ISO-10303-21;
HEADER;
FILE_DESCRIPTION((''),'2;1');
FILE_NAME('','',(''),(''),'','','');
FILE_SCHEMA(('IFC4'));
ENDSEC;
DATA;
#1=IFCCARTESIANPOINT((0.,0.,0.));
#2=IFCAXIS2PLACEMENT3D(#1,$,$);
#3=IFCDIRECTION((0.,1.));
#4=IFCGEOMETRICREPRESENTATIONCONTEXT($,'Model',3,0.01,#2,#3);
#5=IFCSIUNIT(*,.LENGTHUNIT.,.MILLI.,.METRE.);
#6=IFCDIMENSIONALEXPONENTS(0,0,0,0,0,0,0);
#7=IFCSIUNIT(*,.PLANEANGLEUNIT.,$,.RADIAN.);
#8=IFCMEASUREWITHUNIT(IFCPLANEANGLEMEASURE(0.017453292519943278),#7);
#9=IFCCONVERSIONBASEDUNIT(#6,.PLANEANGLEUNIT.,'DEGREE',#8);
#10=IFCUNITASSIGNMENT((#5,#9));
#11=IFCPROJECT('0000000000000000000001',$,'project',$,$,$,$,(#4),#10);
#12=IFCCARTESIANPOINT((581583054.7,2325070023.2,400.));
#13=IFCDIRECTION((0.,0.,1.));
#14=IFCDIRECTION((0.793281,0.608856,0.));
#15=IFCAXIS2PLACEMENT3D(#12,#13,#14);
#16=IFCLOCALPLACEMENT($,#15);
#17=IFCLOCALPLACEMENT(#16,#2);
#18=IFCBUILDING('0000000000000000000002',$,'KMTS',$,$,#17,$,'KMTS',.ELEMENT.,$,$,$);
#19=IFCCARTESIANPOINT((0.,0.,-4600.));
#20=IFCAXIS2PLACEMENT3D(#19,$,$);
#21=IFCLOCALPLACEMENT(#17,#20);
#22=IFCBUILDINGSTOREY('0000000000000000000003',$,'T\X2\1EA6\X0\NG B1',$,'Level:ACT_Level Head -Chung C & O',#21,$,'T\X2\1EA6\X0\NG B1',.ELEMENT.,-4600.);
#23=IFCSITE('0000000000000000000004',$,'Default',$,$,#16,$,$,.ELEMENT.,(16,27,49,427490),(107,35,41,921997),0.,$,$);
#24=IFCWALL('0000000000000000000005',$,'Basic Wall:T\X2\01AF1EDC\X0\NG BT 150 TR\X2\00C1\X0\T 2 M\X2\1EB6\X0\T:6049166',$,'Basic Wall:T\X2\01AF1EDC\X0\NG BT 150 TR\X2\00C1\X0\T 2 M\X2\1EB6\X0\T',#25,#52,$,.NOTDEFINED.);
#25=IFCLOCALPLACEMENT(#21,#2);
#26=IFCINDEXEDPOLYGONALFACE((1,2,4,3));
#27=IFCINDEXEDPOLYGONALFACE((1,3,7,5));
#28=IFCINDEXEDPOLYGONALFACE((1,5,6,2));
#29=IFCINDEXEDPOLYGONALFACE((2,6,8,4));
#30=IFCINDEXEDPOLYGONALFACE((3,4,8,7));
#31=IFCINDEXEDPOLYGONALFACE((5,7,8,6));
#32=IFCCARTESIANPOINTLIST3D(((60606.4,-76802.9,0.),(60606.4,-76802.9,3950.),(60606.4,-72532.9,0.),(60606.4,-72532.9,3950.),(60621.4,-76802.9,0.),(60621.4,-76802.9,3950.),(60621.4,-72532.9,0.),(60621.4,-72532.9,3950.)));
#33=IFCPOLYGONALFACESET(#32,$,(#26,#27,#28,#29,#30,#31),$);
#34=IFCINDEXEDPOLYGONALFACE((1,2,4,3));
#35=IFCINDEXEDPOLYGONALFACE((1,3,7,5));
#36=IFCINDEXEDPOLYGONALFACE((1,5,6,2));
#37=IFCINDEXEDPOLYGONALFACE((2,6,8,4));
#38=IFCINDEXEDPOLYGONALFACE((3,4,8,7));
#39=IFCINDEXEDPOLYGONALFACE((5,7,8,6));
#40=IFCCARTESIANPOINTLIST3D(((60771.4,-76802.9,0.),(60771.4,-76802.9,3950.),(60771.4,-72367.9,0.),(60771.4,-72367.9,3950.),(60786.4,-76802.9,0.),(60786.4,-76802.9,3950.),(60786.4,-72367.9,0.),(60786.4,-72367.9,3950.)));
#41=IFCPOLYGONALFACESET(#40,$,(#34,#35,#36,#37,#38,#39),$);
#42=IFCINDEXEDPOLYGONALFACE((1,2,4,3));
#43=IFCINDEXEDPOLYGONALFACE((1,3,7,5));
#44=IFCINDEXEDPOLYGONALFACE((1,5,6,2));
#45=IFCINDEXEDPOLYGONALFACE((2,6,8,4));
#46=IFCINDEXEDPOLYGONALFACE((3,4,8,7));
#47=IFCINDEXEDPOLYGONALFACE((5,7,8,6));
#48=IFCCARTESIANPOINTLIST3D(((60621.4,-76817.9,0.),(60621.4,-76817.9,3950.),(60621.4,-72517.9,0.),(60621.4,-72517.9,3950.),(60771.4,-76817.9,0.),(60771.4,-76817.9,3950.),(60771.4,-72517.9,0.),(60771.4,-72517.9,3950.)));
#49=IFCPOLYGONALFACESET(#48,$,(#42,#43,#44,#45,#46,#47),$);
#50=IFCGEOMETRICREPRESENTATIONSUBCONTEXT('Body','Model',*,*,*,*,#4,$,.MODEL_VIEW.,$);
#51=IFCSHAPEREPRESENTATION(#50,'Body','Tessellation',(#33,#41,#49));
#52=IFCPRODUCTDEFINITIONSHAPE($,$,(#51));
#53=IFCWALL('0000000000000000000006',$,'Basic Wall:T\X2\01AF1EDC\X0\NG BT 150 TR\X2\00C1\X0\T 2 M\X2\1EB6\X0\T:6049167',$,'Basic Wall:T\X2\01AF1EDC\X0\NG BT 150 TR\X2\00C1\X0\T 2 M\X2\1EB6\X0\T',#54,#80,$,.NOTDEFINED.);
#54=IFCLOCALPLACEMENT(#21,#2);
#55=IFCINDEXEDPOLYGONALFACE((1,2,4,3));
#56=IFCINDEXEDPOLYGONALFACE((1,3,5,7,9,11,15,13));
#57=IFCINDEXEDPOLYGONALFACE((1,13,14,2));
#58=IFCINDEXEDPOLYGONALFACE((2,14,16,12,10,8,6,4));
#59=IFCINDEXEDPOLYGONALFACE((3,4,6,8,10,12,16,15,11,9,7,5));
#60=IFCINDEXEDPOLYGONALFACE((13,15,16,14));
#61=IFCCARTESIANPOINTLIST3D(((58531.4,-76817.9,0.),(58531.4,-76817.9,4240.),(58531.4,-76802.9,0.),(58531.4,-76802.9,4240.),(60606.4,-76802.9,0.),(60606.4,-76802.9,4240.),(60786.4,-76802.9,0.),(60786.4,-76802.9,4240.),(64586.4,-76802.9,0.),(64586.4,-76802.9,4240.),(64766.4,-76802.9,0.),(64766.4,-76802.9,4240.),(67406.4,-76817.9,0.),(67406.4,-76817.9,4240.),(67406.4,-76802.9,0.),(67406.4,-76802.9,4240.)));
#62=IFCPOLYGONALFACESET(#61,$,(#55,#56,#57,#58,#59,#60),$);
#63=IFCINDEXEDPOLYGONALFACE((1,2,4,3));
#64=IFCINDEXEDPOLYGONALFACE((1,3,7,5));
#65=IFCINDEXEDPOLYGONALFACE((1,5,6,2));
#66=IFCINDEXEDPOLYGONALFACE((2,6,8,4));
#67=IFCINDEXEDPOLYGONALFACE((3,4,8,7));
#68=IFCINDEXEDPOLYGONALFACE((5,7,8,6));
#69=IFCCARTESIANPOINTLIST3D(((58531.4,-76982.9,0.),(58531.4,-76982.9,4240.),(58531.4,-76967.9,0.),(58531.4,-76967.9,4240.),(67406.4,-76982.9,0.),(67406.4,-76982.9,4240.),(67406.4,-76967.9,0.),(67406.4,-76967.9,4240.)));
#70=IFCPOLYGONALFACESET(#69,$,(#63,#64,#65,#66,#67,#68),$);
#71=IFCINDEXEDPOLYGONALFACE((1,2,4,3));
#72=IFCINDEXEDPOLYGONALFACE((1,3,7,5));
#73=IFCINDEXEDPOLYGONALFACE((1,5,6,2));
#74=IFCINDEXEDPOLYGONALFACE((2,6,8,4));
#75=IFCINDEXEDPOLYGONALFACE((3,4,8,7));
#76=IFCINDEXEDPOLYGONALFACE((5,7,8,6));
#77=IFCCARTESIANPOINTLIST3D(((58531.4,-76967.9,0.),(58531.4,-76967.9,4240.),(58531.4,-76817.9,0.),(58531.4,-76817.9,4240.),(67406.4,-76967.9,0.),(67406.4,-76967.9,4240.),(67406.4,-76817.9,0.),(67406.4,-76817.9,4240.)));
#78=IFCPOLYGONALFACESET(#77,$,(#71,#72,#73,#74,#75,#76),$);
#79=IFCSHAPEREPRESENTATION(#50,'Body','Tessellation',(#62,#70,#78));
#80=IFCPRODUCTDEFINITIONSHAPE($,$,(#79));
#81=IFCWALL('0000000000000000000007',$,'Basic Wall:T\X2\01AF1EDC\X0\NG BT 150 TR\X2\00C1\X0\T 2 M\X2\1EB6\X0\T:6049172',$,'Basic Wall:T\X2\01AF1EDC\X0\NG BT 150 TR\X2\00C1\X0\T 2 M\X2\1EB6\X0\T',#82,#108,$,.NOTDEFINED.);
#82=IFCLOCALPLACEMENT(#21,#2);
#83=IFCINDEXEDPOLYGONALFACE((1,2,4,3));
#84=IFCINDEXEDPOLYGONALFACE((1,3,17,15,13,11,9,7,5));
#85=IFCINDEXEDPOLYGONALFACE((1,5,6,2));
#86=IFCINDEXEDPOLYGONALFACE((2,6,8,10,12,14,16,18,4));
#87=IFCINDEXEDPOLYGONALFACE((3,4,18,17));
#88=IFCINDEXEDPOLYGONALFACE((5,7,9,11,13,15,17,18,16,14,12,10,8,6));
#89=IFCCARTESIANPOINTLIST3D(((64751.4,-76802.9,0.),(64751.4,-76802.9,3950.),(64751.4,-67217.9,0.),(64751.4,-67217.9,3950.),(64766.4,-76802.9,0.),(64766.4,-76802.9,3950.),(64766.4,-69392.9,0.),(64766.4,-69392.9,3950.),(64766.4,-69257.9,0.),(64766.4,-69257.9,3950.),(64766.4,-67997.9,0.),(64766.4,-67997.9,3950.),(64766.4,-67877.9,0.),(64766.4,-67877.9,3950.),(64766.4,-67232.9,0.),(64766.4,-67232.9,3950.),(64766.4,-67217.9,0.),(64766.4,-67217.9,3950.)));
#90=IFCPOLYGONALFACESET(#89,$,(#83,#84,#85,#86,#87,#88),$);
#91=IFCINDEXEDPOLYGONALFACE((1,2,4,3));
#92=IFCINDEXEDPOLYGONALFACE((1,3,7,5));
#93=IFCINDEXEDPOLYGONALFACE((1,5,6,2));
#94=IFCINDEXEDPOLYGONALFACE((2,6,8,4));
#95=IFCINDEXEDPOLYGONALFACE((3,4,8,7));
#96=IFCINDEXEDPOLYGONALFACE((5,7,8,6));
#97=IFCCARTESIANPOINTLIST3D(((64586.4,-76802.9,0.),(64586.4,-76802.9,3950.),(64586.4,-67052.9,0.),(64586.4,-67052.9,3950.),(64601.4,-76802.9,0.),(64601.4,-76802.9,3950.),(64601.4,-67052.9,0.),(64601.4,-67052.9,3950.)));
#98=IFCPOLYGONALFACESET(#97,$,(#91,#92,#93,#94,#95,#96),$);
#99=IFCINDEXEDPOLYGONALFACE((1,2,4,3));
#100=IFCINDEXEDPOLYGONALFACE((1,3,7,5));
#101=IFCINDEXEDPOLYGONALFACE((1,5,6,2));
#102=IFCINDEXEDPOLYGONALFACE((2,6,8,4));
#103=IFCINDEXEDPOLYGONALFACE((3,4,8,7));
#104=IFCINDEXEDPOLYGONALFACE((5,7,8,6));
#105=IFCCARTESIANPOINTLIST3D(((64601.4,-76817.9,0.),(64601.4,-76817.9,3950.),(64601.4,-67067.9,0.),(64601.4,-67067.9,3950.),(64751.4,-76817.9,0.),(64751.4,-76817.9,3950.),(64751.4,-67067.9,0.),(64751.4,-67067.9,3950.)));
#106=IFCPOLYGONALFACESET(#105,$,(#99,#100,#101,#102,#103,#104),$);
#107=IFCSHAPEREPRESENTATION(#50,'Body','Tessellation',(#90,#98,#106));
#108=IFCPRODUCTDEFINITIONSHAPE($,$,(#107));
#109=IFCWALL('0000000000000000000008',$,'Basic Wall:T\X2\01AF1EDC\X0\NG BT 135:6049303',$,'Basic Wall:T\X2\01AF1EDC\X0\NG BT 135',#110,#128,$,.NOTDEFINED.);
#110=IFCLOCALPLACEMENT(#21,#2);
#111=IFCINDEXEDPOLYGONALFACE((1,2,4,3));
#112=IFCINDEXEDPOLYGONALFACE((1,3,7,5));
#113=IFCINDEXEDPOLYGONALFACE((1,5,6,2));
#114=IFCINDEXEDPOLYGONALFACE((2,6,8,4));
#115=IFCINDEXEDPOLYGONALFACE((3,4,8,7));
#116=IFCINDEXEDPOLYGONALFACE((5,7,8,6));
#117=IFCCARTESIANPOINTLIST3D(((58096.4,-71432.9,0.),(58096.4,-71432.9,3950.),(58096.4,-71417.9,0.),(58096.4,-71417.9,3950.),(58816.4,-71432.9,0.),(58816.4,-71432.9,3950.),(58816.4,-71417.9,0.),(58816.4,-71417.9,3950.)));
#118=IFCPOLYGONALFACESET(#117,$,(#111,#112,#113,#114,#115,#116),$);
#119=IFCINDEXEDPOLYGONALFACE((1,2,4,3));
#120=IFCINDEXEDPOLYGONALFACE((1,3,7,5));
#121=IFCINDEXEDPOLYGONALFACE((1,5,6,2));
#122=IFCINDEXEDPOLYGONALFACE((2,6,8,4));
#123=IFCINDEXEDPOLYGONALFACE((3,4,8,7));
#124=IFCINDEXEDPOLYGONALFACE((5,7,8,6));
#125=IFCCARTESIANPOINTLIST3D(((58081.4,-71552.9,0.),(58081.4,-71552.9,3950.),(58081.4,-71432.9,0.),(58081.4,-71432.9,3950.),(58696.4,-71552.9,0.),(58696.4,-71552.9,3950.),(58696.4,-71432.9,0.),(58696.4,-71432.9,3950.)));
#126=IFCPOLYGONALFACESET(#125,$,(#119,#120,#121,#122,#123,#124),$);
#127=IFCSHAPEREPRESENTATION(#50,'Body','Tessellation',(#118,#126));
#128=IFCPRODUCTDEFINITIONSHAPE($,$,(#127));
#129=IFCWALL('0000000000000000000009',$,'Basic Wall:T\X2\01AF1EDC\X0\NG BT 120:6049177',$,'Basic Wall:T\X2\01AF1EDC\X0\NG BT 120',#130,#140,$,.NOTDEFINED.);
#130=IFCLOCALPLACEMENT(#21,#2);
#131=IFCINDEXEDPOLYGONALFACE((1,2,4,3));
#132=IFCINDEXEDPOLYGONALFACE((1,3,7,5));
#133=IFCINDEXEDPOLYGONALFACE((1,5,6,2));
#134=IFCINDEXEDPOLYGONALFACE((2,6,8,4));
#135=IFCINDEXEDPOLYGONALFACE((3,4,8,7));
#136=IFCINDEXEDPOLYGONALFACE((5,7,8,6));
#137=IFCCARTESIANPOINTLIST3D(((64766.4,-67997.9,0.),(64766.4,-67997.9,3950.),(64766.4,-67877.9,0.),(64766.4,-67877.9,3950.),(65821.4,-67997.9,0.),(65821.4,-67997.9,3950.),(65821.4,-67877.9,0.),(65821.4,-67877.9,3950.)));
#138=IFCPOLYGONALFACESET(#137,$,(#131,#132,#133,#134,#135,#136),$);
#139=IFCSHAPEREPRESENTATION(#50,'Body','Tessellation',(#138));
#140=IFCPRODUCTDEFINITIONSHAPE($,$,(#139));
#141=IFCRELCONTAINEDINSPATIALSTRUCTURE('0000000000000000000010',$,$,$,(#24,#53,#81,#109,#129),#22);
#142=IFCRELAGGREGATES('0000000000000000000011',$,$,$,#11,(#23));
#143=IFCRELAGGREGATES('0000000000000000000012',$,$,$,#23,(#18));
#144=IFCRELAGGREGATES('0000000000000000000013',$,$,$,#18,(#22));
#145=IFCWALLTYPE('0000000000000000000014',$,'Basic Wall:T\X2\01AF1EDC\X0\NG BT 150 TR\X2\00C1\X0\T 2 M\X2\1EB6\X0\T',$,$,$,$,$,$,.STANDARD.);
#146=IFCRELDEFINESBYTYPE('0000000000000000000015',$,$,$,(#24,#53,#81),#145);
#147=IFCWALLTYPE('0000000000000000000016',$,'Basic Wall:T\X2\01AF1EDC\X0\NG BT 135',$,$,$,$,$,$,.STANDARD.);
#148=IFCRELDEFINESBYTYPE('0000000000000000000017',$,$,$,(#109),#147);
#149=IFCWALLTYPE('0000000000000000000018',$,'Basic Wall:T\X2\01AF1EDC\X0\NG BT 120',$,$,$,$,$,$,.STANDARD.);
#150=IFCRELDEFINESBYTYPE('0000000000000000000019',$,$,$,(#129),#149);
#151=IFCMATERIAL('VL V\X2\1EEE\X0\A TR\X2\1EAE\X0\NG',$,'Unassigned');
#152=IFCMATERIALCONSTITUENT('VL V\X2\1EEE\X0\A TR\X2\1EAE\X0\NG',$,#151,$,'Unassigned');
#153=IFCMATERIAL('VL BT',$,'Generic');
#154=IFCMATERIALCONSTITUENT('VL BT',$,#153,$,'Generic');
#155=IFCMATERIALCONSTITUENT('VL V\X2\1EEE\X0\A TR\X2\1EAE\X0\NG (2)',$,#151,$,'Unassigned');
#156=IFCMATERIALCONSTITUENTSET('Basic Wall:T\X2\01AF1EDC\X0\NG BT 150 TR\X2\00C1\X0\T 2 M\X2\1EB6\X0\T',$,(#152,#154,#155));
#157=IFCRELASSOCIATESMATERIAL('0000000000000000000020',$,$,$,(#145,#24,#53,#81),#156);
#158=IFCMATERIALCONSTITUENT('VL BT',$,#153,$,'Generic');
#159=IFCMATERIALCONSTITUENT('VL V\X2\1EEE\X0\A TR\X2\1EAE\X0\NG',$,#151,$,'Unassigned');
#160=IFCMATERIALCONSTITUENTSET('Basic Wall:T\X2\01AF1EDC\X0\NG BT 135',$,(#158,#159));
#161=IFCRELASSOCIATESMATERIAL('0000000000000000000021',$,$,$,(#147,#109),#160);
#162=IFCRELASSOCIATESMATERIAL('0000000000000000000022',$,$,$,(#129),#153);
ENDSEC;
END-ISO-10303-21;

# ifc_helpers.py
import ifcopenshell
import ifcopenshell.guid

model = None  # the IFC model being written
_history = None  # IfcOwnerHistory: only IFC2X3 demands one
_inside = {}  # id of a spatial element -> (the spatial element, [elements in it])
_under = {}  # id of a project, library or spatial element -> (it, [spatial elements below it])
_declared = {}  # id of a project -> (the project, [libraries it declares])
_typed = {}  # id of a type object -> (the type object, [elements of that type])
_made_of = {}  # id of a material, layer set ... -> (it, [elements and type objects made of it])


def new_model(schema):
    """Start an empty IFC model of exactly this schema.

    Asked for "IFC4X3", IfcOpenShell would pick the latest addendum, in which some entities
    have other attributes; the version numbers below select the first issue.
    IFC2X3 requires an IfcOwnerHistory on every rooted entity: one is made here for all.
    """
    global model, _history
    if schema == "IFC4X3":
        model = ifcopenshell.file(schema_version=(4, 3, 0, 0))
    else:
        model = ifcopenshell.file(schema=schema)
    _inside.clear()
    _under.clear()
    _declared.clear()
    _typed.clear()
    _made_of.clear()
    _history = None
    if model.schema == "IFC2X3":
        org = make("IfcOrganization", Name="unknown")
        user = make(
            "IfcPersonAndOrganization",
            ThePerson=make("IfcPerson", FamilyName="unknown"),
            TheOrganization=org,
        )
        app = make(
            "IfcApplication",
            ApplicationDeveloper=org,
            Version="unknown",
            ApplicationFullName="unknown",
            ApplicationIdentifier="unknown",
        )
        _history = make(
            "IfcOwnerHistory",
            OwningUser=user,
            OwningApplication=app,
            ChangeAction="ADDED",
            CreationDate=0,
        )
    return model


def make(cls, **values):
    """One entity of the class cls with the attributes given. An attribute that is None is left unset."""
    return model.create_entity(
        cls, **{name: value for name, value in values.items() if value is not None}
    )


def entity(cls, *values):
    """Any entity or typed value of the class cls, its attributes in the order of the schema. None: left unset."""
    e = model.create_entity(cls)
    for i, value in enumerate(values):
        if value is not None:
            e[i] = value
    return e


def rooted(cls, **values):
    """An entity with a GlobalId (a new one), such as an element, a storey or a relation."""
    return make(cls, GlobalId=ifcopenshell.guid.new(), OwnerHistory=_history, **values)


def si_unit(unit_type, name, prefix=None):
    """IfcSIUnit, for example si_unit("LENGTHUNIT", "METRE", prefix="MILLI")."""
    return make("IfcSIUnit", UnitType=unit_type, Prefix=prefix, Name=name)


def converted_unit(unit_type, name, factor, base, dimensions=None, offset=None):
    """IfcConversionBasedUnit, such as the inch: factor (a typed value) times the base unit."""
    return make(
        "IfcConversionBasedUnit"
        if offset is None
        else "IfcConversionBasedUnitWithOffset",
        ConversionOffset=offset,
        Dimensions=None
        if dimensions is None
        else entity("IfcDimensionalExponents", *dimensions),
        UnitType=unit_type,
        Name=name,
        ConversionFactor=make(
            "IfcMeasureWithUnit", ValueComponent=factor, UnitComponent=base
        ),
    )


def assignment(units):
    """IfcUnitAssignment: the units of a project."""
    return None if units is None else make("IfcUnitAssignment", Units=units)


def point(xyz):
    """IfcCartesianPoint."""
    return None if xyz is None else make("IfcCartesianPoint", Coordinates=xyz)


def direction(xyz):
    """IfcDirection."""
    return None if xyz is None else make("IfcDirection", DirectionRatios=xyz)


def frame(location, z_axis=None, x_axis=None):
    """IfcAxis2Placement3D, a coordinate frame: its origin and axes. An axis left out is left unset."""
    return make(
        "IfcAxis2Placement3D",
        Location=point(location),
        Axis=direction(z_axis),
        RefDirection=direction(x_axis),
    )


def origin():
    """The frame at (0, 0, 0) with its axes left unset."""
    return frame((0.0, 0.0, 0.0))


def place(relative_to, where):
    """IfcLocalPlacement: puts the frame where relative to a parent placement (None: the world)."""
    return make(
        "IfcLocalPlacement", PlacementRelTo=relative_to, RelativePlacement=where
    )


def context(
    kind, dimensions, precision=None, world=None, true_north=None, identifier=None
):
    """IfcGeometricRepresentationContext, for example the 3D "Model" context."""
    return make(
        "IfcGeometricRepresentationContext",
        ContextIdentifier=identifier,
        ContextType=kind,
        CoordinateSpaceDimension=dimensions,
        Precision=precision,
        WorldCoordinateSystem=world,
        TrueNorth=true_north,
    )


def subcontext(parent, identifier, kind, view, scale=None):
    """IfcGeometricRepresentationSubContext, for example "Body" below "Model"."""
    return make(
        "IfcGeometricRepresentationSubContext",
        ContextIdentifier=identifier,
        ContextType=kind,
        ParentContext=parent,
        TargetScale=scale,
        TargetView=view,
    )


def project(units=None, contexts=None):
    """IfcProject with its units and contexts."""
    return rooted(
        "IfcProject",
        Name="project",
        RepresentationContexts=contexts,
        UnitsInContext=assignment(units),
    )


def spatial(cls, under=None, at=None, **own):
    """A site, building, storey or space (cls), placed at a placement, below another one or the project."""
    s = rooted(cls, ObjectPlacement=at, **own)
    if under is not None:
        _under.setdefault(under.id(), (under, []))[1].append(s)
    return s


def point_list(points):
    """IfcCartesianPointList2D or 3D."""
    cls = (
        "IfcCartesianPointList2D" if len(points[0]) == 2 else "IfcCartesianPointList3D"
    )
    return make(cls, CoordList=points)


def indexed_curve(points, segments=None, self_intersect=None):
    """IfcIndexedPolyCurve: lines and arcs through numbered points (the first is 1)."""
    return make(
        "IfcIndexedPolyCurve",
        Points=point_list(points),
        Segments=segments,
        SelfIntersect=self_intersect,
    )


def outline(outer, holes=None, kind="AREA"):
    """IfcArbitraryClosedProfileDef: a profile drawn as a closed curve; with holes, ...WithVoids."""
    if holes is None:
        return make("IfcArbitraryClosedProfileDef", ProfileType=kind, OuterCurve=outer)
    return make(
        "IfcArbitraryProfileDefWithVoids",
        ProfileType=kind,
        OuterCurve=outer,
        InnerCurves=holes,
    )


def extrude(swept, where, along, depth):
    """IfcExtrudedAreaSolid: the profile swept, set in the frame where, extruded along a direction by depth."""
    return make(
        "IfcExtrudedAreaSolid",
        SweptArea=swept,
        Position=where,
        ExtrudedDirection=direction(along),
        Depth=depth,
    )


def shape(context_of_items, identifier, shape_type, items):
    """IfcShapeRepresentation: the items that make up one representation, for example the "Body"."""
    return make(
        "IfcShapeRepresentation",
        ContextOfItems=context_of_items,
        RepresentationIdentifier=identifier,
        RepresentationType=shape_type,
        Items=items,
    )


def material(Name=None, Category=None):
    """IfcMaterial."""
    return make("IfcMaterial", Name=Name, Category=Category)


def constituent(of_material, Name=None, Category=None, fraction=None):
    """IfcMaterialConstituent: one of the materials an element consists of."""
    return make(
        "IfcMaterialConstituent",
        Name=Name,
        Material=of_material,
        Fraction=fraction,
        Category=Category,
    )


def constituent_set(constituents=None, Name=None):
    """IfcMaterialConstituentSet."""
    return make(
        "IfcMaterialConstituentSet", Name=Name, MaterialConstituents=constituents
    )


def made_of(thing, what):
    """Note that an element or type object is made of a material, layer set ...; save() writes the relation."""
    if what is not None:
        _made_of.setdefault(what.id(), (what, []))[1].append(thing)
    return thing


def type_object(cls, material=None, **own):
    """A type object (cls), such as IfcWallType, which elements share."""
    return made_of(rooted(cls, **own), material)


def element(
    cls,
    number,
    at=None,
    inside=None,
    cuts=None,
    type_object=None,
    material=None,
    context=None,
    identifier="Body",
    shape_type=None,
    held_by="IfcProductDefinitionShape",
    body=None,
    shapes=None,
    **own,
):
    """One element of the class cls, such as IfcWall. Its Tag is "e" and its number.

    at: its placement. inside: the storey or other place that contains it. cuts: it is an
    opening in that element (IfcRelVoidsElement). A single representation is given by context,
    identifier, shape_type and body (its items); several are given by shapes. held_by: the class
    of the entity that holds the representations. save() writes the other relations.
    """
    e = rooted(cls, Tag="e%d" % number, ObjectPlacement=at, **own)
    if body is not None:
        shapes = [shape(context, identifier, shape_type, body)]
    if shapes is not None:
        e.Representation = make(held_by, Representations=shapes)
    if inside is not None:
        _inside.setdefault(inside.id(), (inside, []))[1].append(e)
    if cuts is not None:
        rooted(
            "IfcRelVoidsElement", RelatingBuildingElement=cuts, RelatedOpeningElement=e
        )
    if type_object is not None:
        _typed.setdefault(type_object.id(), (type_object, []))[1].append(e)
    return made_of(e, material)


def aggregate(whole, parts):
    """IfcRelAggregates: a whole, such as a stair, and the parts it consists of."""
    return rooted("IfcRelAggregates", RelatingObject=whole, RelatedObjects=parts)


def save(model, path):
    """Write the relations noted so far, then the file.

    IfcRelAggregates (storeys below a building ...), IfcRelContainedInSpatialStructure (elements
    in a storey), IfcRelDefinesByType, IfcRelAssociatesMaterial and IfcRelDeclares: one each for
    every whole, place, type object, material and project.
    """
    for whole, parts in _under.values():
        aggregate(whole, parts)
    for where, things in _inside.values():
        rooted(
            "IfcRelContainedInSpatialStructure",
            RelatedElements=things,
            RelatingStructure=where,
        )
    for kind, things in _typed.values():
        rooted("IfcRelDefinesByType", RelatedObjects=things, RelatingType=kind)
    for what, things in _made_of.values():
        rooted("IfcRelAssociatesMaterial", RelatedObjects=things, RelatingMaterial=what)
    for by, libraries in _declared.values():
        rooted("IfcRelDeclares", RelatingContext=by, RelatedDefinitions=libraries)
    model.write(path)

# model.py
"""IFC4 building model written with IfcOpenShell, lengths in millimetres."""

from ifc_helpers import new_model, entity, si_unit, converted_unit, direction, frame, origin, place, context, subcontext, project, spatial, indexed_curve, outline, extrude, material, constituent, constituent_set, type_object, element, save


model = new_model("IFC4")

# Units and contexts
model_context = context("Model", 3, precision=0.01, world=origin(), true_north=direction((0.0, 1.0)))
body_context = subcontext(model_context, "Body", "Model", "MODEL_VIEW")
ifc_project = project(units=[si_unit("LENGTHUNIT", "METRE", prefix="MILLI"), converted_unit("PLANEANGLEUNIT", "DEGREE", entity("IfcPlaneAngleMeasure", 0.017453292519943278), si_unit("PLANEANGLEUNIT", "RADIAN"), dimensions=[0, 0, 0, 0, 0, 0, 0])], contexts=[model_context])

# Site, building, storey
site_placement = place(None, frame((581583054.7, 2325070023.2, 400.0), z_axis=(0.0, 0.0, 1.0), x_axis=(0.793281, 0.608856, 0.0)))
site = spatial("IfcSite", under=ifc_project, at=site_placement, Name="Default", CompositionType="ELEMENT", RefLatitude=(16, 27, 49, 427490), RefLongitude=(107, 35, 41, 921997), RefElevation=0.0)
building_placement = place(site_placement, origin())
building = spatial("IfcBuilding", under=site, at=building_placement, Name="KMTS", LongName="KMTS", CompositionType="ELEMENT")
storey_placement = place(building_placement, frame((0.0, 0.0, -4600.0)))
storey = spatial("IfcBuildingStorey", under=building, at=storey_placement, Name="TẦNG B1", ObjectType="Level:ACT_Level Head -Chung C & O", LongName="TẦNG B1", CompositionType="ELEMENT", Elevation=-4600.0)

# Shared definitions
ifc_material_1 = material(Name="VL VỮA TRẮNG", Category="Unassigned")
ifc_constituent_1 = constituent(ifc_material_1, Name="VL VỮA TRẮNG", Category="Unassigned")
ifc_material_2 = material(Name="VL BT", Category="Generic")
ifc_constituent_2 = constituent(ifc_material_2, Name="VL BT", Category="Generic")
ifc_constituent_3 = constituent(ifc_material_1, Name="VL VỮA TRẮNG (2)", Category="Unassigned")
ifc_constituent_set_1 = constituent_set(constituents=[ifc_constituent_1, ifc_constituent_2, ifc_constituent_3], Name="Basic Wall:TƯỜNG BT 150 TRÁT 2 MẶT")
wall_type_1 = type_object("IfcWallType", Name="Basic Wall:TƯỜNG BT 150 TRÁT 2 MẶT", PredefinedType="STANDARD", material=ifc_constituent_set_1)

# Walls
wall_1_placement = place(storey_placement, frame((60696.4, -72532.9, 0.0), z_axis=(0.0, 0.0, 1.0), x_axis=(0.0, -1.0, 0.0)))
element("IfcWall", 1, at=wall_1_placement, inside=storey, type_object=wall_type_1, material=ifc_constituent_set_1, Name="Basic Wall:TƯỜNG BT 150 TRÁT 2 MẶT:6049166", ObjectType="Basic Wall:TƯỜNG BT 150 TRÁT 2 MẶT", PredefinedType="NOTDEFINED", context=body_context, shape_type="SweptSolid", body=[
    extrude(outline(indexed_curve([(-7.5, -2135.0), (7.5, -2135.0), (7.5, 2135.0), (-7.5, 2135.0), (-7.5, -2135.0)], self_intersect=False)), frame((2135.0, -82.5, 0.0), z_axis=(0.0, 0.0, 1.0), x_axis=(0.0, 1.0, 0.0)), (0.0, 0.0, 1.0), 3950.0),
    extrude(outline(indexed_curve([(-7.5, -2217.5), (7.5, -2217.5), (7.5, 2217.5), (-7.5, 2217.5), (-7.5, -2217.5)], self_intersect=False)), frame((2052.5, 82.5, 0.0), z_axis=(0.0, 0.0, 1.0), x_axis=(0.0, -1.0, 0.0)), (0.0, 0.0, 1.0), 3950.0),
    extrude(outline(indexed_curve([(-2150.0, -75.0), (2150.0, -75.0), (2150.0, 75.0), (-2150.0, 75.0), (-2150.0, -75.0)], self_intersect=False)), frame((2135.0, 0.0, 0.0)), (0.0, 0.0, 1.0), 3950.0),
])
wall_2_placement = place(storey_placement, frame((67406.4, -76892.9, 0.0), z_axis=(0.0, 0.0, 1.0), x_axis=(-1.0, 0.0, 0.0)))
element("IfcWall", 2, at=wall_2_placement, inside=storey, type_object=wall_type_1, material=ifc_constituent_set_1, Name="Basic Wall:TƯỜNG BT 150 TRÁT 2 MẶT:6049167", ObjectType="Basic Wall:TƯỜNG BT 150 TRÁT 2 MẶT", PredefinedType="NOTDEFINED", context=body_context, shape_type="SweptSolid", body=[
    extrude(outline(indexed_curve([(-1938.7, -3.7), (-1758.7, -3.7), (2041.3, -3.8), (2221.3, -3.8), (4296.2, -3.8), (4296.2, 11.2), (-4578.7, 11.3), (-4578.7, -3.7), (-1938.7, -3.7)], self_intersect=False)), frame((4578.7, -86.3, 0.0)), (0.0, 0.0, 1.0), 4240.0),
    extrude(outline(indexed_curve([(-7.5, -4437.5), (7.5, -4437.5), (7.5, 4437.5), (-7.5, 4437.5), (-7.5, -4437.5)], self_intersect=False)), frame((4437.5, 82.5, 0.0), z_axis=(0.0, 0.0, 1.0), x_axis=(0.0, -1.0, 0.0)), (0.0, 0.0, 1.0), 4240.0),
    extrude(outline(indexed_curve([(-4437.5, -75.0), (4437.5, -75.0), (4437.5, 75.0), (-4437.5, 75.0), (-4437.5, -75.0)], self_intersect=False)), frame((4437.5, 0.0, 0.0)), (0.0, 0.0, 1.0), 4240.0),
])
wall_3_placement = place(storey_placement, frame((64676.4, -76802.9, 0.0), z_axis=(0.0, 0.0, 1.0), x_axis=(0.0, 1.0, 0.0)))
element("IfcWall", 3, at=wall_3_placement, inside=storey, type_object=wall_type_1, material=ifc_constituent_set_1, Name="Basic Wall:TƯỜNG BT 150 TRÁT 2 MẶT:6049172", ObjectType="Basic Wall:TƯỜNG BT 150 TRÁT 2 MẶT", PredefinedType="NOTDEFINED", context=body_context, shape_type="SweptSolid", body=[
    extrude(outline(indexed_curve([(585.0, -3.3), (720.0, -3.3), (1980.0, -3.3), (2100.0, -3.3), (2745.0, -3.3), (2760.0, -3.3), (2760.0, 11.7), (-6825.0, 11.7), (-6825.0, -3.3), (585.0, -3.3)], self_intersect=False)), frame((6825.0, -86.7, 0.0)), (0.0, 0.0, 1.0), 3950.0),
    extrude(outline(indexed_curve([(-7.5, -4875.0), (7.5, -4875.0), (7.5, 4875.0), (-7.5, 4875.0), (-7.5, -4875.0)], self_intersect=False)), frame((4875.0, 82.5, 0.0), z_axis=(0.0, 0.0, 1.0), x_axis=(0.0, -1.0, 0.0)), (0.0, 0.0, 1.0), 3950.0),
    extrude(outline(indexed_curve([(-4875.0, -75.0), (4875.0, -75.0), (4875.0, 75.0), (-4875.0, 75.0), (-4875.0, -75.0)], self_intersect=False)), frame((4860.0, 0.0, 0.0)), (0.0, 0.0, 1.0), 3950.0),
])

# Shared definitions
ifc_constituent_4 = constituent(ifc_material_2, Name="VL BT", Category="Generic")
ifc_constituent_5 = constituent(ifc_material_1, Name="VL VỮA TRẮNG", Category="Unassigned")
ifc_constituent_set_2 = constituent_set(constituents=[ifc_constituent_4, ifc_constituent_5], Name="Basic Wall:TƯỜNG BT 135")
wall_type_2 = type_object("IfcWallType", Name="Basic Wall:TƯỜNG BT 135", PredefinedType="STANDARD", material=ifc_constituent_set_2)

# Walls
wall_4_placement = place(storey_placement, frame((58696.4, -71485.4, 0.0), z_axis=(0.0, 0.0, 1.0), x_axis=(-1.0, 0.0, 0.0)))
element("IfcWall", 4, at=wall_4_placement, inside=storey, type_object=wall_type_2, material=ifc_constituent_set_2, Name="Basic Wall:TƯỜNG BT 135:6049303", ObjectType="Basic Wall:TƯỜNG BT 135", PredefinedType="NOTDEFINED", context=body_context, shape_type="SweptSolid", body=[
    extrude(outline(indexed_curve([(-7.5, -360.0), (7.5, -360.0), (7.5, 360.0), (-7.5, 360.0), (-7.5, -360.0)], self_intersect=False)), frame((240.0, -60.0, 0.0), z_axis=(0.0, 0.0, 1.0), x_axis=(0.0, 1.0, 0.0)), (0.0, 0.0, 1.0), 3950.0),
    extrude(outline(indexed_curve([(-60.0, -307.5), (60.0, -307.5), (60.0, 307.5), (-60.0, 307.5), (-60.0, -307.5)], self_intersect=False)), frame((307.5, 7.5, 0.0), z_axis=(0.0, 0.0, 1.0), x_axis=(0.0, -1.0, 0.0)), (0.0, 0.0, 1.0), 3950.0),
])
wall_type_3 = type_object("IfcWallType", Name="Basic Wall:TƯỜNG BT 120", PredefinedType="STANDARD")
wall_5_placement = place(storey_placement, frame((64766.4, -67937.9, 0.0)))
element("IfcWall", 5, at=wall_5_placement, inside=storey, type_object=wall_type_3, material=ifc_material_2, Name="Basic Wall:TƯỜNG BT 120:6049177", ObjectType="Basic Wall:TƯỜNG BT 120", PredefinedType="NOTDEFINED", context=body_context, shape_type="SweptSolid", body=[
    extrude(outline(indexed_curve([(1055.0, 60.0), (0.0, 60.0), (0.0, -60.0), (1055.0, -60.0), (1055.0, 60.0)], self_intersect=False)), origin(), (0.0, 0.0, 1.0), 3950.0),
])

save(model, "model.ifc")
